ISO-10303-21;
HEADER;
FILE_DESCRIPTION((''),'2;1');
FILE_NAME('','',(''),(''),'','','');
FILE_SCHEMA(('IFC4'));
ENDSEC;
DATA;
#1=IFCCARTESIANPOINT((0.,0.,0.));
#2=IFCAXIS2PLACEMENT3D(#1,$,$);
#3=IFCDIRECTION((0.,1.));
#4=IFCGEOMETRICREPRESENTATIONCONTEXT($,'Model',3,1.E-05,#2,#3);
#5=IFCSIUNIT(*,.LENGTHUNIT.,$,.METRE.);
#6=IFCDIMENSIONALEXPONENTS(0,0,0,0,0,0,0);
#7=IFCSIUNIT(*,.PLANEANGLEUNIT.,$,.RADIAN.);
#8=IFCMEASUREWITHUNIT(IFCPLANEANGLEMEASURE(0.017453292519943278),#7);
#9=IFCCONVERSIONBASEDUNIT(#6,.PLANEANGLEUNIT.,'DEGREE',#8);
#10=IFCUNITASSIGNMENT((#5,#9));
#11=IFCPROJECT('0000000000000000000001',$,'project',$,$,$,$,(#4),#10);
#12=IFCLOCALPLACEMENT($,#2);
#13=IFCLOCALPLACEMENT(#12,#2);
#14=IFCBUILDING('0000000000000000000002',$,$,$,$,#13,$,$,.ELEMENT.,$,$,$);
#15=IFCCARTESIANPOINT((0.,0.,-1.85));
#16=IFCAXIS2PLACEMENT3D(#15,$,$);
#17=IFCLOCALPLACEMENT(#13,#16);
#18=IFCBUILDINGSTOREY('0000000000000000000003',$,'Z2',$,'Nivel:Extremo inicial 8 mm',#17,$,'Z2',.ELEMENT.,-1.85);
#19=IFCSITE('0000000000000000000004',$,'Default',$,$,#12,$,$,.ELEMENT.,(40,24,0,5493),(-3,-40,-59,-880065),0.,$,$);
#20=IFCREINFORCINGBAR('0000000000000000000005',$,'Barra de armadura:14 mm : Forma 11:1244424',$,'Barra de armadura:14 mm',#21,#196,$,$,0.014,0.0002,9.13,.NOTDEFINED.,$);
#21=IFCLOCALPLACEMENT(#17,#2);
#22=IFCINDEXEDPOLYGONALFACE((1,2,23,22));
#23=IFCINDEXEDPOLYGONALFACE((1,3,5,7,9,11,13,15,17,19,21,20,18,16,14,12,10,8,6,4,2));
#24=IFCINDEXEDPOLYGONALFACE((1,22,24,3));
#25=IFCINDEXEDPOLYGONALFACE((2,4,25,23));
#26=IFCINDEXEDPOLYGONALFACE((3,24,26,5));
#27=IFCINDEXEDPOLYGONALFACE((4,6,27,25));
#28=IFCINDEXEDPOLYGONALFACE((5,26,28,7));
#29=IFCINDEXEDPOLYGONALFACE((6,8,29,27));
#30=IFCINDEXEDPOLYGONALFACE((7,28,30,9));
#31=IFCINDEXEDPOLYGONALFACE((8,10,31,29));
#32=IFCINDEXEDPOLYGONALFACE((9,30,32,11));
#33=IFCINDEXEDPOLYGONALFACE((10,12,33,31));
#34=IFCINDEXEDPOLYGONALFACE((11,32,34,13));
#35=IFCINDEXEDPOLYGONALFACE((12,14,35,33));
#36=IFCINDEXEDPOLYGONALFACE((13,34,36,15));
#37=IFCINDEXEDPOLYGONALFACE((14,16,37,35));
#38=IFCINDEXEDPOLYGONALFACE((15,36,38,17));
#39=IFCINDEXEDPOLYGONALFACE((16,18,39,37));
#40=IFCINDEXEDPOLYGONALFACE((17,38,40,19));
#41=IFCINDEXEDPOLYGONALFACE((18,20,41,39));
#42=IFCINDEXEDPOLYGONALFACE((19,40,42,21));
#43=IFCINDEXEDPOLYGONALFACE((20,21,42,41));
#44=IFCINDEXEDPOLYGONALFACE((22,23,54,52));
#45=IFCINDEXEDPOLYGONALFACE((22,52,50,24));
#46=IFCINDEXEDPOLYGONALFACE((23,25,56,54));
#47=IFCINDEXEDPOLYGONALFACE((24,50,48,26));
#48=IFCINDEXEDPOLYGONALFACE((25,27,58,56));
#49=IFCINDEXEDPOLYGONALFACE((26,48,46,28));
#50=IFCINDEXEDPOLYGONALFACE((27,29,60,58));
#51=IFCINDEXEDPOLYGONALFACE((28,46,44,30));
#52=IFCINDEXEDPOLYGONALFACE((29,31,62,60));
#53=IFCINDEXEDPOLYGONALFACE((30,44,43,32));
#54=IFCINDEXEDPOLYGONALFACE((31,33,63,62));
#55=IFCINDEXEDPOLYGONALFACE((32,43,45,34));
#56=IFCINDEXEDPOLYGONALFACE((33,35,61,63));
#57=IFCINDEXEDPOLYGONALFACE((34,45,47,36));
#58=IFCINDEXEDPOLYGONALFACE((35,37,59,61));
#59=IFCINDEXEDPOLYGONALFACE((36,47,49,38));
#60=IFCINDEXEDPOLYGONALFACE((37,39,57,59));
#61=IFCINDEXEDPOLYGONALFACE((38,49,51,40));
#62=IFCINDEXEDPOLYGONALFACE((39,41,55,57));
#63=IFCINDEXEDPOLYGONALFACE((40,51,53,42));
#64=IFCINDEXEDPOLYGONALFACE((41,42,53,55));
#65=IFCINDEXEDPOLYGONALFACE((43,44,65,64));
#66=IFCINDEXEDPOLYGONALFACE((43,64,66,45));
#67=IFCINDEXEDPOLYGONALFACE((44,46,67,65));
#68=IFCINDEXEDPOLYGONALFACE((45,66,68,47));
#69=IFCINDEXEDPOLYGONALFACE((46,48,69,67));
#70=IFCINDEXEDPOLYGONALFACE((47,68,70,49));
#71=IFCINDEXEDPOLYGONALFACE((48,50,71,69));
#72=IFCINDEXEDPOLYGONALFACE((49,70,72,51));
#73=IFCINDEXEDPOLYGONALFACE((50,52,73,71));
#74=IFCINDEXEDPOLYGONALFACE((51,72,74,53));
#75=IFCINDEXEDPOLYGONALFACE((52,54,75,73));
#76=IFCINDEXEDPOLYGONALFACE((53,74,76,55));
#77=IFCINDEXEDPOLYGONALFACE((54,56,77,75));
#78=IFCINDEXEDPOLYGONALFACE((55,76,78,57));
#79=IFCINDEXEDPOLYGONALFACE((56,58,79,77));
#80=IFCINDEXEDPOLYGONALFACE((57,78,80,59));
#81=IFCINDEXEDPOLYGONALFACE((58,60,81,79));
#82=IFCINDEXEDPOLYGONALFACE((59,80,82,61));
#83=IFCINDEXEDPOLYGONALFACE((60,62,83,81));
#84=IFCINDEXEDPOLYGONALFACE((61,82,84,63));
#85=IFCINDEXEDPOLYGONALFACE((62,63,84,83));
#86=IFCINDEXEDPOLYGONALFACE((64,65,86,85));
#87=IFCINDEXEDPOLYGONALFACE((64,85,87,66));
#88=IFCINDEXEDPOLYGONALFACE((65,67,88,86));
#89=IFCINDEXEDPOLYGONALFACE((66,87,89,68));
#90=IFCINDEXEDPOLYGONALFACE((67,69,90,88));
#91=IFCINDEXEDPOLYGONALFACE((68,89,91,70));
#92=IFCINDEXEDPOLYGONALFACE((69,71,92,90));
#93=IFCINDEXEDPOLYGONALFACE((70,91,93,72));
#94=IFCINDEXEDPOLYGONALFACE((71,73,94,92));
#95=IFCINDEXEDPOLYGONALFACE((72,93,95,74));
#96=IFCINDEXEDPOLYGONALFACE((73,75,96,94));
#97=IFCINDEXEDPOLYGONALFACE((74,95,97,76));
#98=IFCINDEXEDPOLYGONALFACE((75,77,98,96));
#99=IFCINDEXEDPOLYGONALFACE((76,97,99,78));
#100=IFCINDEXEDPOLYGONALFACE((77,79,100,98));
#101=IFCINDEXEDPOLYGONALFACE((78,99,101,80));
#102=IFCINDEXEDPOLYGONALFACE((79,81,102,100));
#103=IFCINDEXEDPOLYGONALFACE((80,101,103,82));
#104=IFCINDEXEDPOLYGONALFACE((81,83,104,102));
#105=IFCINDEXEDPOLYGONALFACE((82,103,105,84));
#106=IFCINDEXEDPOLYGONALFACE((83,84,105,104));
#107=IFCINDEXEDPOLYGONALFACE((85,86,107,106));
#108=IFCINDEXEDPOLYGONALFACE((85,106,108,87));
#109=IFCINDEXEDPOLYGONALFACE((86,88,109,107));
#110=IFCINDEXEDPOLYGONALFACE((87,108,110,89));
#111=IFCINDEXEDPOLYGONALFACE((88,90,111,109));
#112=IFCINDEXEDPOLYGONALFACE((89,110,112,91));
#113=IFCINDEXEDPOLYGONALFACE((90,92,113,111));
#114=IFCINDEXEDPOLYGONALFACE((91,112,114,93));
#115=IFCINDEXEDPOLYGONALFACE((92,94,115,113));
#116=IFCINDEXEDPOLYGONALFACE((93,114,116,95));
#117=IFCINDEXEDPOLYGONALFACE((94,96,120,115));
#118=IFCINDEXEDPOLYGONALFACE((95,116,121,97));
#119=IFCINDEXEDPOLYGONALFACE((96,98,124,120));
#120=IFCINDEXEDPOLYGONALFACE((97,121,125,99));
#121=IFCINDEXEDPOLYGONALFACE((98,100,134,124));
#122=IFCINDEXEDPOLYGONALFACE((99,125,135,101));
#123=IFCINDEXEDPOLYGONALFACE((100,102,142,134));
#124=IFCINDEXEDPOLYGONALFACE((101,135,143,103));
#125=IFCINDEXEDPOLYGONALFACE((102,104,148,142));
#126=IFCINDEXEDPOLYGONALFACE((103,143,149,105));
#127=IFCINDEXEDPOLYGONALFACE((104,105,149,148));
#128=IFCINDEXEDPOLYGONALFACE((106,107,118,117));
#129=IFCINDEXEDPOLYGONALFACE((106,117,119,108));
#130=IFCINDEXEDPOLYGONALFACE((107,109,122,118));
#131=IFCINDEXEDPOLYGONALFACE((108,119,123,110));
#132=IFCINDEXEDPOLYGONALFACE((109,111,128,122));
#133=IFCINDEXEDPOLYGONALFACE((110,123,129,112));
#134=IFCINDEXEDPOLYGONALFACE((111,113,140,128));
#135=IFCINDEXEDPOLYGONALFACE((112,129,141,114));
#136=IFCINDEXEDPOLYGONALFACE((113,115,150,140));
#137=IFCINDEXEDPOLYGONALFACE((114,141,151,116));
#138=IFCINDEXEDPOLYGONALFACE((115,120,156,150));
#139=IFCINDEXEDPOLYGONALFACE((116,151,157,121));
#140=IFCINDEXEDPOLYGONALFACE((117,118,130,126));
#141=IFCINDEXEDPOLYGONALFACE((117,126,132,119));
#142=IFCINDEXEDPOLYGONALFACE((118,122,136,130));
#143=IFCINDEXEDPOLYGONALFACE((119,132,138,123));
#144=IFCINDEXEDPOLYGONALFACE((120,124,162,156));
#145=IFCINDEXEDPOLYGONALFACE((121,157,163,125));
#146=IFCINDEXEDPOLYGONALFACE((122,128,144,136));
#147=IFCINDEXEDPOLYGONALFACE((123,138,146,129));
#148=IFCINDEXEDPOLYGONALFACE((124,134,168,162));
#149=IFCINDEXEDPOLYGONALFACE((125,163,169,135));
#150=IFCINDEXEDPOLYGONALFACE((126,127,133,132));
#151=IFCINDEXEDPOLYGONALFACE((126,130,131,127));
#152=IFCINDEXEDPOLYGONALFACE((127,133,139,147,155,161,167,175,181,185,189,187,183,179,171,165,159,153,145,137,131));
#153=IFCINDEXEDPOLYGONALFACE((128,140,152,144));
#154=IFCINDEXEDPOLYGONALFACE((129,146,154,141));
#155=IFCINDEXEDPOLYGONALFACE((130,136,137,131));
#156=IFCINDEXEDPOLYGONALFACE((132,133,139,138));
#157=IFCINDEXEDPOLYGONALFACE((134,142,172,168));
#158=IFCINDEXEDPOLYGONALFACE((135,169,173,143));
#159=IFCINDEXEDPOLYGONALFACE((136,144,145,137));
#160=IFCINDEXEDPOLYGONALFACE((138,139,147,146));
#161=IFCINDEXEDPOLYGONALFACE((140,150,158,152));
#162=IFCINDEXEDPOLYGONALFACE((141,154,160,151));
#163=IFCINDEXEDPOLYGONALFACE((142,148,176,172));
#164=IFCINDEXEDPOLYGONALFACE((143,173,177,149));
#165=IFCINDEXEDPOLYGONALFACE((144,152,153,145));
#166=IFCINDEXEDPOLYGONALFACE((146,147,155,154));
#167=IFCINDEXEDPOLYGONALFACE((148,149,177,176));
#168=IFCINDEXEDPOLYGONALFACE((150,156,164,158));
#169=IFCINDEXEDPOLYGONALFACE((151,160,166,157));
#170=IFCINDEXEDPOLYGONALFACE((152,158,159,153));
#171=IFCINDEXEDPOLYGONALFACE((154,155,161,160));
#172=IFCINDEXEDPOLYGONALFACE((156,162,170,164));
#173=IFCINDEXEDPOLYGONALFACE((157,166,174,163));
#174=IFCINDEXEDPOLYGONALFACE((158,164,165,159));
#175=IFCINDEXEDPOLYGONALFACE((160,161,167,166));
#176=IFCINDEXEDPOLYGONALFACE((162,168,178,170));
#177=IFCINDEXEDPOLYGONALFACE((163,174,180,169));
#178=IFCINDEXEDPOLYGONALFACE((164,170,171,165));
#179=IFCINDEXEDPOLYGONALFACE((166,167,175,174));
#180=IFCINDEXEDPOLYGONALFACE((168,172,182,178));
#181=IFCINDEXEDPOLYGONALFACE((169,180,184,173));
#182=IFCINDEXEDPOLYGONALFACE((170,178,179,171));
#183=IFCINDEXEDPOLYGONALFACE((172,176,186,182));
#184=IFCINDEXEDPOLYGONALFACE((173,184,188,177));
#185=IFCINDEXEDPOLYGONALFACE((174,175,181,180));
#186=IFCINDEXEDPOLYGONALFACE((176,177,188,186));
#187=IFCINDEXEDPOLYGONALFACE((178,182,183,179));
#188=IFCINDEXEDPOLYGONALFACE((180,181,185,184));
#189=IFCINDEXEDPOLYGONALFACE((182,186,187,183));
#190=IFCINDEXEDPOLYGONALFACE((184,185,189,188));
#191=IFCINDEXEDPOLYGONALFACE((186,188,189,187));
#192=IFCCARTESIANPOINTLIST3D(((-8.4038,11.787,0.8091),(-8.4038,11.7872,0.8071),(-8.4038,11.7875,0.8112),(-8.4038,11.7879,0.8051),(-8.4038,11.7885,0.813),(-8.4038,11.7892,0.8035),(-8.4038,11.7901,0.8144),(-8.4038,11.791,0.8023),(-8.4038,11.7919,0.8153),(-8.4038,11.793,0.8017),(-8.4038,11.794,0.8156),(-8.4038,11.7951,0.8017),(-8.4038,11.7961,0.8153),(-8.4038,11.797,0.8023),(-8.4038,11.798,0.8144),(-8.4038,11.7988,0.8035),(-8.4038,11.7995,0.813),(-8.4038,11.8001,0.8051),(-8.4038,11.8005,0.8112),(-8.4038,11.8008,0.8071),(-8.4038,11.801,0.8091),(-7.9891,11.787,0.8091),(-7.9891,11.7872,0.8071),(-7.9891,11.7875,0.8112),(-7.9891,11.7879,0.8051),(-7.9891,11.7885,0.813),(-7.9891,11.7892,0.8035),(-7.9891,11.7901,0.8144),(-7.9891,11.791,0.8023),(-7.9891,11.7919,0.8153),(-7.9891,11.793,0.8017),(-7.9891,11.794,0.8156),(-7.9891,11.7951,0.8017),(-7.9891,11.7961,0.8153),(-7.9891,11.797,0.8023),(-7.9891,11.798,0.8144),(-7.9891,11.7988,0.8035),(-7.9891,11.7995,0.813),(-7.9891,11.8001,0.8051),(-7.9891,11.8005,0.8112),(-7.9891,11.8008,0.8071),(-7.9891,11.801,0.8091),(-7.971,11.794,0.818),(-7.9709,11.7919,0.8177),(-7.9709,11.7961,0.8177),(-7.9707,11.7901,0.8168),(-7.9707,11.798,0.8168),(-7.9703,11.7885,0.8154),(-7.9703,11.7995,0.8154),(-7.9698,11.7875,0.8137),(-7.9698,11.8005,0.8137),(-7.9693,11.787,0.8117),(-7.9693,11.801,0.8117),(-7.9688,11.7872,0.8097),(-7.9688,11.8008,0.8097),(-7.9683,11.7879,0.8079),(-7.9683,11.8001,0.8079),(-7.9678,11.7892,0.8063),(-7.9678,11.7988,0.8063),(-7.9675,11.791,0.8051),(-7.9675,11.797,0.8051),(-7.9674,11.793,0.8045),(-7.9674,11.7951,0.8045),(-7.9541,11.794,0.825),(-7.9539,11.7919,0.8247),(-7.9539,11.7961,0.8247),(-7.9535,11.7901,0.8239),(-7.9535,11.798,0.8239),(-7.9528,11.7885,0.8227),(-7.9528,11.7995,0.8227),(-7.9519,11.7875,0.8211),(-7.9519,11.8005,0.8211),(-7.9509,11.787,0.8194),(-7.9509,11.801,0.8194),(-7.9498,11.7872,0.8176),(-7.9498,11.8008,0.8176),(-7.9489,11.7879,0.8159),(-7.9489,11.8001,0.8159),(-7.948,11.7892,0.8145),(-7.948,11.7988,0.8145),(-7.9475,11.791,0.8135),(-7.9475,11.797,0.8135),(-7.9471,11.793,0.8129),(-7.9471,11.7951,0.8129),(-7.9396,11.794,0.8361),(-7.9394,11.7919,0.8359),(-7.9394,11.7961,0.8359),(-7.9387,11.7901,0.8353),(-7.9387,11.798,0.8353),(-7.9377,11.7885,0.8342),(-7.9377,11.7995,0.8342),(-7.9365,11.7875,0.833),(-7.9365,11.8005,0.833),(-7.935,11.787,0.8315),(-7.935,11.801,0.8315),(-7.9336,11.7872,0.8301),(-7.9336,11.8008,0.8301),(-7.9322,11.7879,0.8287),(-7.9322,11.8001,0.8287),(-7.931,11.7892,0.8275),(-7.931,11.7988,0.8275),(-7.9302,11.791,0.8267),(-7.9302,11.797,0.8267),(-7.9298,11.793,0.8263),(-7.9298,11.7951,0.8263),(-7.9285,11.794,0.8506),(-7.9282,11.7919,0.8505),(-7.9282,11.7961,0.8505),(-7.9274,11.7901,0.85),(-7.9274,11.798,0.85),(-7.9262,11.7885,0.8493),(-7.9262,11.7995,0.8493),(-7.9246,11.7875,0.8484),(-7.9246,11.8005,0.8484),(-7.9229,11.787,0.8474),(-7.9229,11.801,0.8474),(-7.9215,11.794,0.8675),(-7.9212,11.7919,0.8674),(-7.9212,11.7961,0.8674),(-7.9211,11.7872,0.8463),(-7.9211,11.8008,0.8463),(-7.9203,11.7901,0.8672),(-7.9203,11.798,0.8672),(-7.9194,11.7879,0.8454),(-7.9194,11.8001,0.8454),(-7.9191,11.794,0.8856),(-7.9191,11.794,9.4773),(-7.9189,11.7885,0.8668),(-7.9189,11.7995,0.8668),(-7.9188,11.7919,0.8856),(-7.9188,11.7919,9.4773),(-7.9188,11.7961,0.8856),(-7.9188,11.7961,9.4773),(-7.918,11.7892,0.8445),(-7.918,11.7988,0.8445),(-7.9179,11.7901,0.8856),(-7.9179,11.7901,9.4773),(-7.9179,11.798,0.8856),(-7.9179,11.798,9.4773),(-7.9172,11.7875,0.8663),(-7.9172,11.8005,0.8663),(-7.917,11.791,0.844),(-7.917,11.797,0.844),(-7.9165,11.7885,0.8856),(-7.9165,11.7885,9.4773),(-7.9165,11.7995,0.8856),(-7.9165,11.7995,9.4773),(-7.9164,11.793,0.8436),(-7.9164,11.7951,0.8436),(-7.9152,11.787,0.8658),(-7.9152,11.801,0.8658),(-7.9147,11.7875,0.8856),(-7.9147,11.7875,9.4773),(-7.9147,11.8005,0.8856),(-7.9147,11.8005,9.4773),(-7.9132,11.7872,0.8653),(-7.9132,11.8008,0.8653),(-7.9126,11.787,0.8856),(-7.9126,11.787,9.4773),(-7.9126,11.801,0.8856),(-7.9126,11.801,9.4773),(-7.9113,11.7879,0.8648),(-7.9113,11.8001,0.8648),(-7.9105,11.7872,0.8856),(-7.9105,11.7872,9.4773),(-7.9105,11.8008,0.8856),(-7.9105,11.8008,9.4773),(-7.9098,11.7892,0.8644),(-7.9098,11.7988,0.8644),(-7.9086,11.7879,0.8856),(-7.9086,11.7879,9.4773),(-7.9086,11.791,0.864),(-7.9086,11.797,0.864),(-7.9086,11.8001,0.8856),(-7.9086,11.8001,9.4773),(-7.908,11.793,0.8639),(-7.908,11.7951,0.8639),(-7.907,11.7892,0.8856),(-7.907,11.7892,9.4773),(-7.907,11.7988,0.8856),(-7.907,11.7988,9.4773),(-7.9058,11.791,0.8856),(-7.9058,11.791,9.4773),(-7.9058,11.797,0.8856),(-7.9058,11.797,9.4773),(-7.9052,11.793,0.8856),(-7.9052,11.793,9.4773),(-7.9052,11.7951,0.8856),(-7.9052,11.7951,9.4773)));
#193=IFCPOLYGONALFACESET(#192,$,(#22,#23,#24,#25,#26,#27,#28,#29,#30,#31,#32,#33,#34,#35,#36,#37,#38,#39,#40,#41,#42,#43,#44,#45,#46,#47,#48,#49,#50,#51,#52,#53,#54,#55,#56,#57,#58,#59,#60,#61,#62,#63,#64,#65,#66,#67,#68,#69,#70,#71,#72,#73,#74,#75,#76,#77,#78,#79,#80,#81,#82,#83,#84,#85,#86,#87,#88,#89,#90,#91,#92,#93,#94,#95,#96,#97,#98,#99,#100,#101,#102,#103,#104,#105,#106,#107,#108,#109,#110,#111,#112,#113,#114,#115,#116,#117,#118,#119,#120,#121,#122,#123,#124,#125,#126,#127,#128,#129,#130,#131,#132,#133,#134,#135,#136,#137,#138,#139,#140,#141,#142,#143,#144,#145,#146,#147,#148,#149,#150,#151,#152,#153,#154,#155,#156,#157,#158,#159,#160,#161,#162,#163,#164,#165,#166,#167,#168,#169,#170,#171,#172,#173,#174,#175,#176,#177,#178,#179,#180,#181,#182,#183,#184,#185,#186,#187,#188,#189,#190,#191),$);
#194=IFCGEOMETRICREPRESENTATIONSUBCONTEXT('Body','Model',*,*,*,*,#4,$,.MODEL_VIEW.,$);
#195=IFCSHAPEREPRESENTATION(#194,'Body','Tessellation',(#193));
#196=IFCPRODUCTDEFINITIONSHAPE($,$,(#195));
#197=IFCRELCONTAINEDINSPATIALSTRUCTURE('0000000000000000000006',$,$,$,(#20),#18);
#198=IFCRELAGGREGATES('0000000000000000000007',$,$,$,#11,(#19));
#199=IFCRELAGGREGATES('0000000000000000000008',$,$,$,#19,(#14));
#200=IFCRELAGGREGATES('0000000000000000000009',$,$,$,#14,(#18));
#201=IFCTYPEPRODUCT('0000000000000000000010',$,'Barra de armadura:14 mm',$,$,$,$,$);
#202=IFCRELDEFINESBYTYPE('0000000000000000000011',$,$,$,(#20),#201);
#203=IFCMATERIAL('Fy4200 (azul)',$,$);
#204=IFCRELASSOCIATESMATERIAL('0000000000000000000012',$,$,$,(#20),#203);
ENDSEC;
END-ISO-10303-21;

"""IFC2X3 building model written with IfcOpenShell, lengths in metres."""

from ifc_helpers import new_model, entity, si_unit, converted_unit, direction, frame, origin, place, context, subcontext, project, spatial, material, type_object, element, save


model = new_model("IFC2X3")

# Units and contexts
model_context = context("Model", 3, precision=1e-05, world=origin(), true_north=direction((0.0, 1.0)))
body_context = subcontext(model_context, "Body", "Model", "MODEL_VIEW")
ifc_project = project(units=[si_unit("LENGTHUNIT", "METRE"), converted_unit("PLANEANGLEUNIT", "DEGREE", entity("IfcPlaneAngleMeasure", 0.017453292519943278), si_unit("PLANEANGLEUNIT", "RADIAN"), dimensions=[0, 0, 0, 0, 0, 0, 0])], contexts=[model_context])

# Site, building, storey
site_placement = place(None, origin())
site = spatial("IfcSite", under=ifc_project, at=site_placement, Name="Default", CompositionType="ELEMENT", RefLatitude=(40, 24, 0, 5493), RefLongitude=(-3, -40, -59, -880065), RefElevation=0.0)
building_placement = place(site_placement, origin())
building = spatial("IfcBuilding", under=site, at=building_placement, CompositionType="ELEMENT")
storey_placement = place(building_placement, frame((0.0, 0.0, -1.85)))
storey = spatial("IfcBuildingStorey", under=building, at=storey_placement, Name="Z2", ObjectType="Nivel:Extremo inicial 8 mm", LongName="Z2", CompositionType="ELEMENT", Elevation=-1.85)

# Reinforcing bar
ifc_material_1 = material(Name="Fy4200 (azul)")
type_product_1 = type_object("IfcTypeProduct", Name="Barra de armadura:14 mm")
reinforcing_bar_1_placement = place(storey_placement, origin())
element("IfcReinforcingBar", 1, at=reinforcing_bar_1_placement, inside=storey, type_object=type_product_1, material=ifc_material_1, Name="Barra de armadura:14 mm : Forma 11:1244424", ObjectType="Barra de armadura:14 mm", BarLength=9.13, BarRole="NOTDEFINED", CrossSectionArea=0.0002, NominalDiameter=0.014, context=body_context, shape_type="AdvancedSweptSolid", body=[
    entity("IfcSweptDiskSolid", entity("IfcCompositeCurve", [entity("IfcCompositeCurveSegment", "CONTINUOUS", True, entity("IfcPolyline", [entity("IfcCartesianPoint", [-7.9121, 11.794, 9.4773]), entity("IfcCartesianPoint", [-7.9121, 11.794, 0.8856])])), entity("IfcCompositeCurveSegment", "CONTINUOUS", True, entity("IfcTrimmedCurve", entity("IfcCircle", entity("IfcAxis2Placement3D", entity("IfcCartesianPoint", [-7.9891, 11.794, 0.8856]), entity("IfcDirection", [0.0, 1.0, 0.0]), entity("IfcDirection", [0.0, 0.0, -1.0])), 0.077), [entity("IfcParameterValue", 270.0)], [entity("IfcParameterValue", 360.0)], True, "PARAMETER")), entity("IfcCompositeCurveSegment", "CONTINUOUS", True, entity("IfcPolyline", [entity("IfcCartesianPoint", [-7.9891, 11.794, 0.8086]), entity("IfcCartesianPoint", [-8.4038, 11.794, 0.8086])]))], False), 0.007, None, 0.0, 92.0),
])

save(model, "model.ifc")
